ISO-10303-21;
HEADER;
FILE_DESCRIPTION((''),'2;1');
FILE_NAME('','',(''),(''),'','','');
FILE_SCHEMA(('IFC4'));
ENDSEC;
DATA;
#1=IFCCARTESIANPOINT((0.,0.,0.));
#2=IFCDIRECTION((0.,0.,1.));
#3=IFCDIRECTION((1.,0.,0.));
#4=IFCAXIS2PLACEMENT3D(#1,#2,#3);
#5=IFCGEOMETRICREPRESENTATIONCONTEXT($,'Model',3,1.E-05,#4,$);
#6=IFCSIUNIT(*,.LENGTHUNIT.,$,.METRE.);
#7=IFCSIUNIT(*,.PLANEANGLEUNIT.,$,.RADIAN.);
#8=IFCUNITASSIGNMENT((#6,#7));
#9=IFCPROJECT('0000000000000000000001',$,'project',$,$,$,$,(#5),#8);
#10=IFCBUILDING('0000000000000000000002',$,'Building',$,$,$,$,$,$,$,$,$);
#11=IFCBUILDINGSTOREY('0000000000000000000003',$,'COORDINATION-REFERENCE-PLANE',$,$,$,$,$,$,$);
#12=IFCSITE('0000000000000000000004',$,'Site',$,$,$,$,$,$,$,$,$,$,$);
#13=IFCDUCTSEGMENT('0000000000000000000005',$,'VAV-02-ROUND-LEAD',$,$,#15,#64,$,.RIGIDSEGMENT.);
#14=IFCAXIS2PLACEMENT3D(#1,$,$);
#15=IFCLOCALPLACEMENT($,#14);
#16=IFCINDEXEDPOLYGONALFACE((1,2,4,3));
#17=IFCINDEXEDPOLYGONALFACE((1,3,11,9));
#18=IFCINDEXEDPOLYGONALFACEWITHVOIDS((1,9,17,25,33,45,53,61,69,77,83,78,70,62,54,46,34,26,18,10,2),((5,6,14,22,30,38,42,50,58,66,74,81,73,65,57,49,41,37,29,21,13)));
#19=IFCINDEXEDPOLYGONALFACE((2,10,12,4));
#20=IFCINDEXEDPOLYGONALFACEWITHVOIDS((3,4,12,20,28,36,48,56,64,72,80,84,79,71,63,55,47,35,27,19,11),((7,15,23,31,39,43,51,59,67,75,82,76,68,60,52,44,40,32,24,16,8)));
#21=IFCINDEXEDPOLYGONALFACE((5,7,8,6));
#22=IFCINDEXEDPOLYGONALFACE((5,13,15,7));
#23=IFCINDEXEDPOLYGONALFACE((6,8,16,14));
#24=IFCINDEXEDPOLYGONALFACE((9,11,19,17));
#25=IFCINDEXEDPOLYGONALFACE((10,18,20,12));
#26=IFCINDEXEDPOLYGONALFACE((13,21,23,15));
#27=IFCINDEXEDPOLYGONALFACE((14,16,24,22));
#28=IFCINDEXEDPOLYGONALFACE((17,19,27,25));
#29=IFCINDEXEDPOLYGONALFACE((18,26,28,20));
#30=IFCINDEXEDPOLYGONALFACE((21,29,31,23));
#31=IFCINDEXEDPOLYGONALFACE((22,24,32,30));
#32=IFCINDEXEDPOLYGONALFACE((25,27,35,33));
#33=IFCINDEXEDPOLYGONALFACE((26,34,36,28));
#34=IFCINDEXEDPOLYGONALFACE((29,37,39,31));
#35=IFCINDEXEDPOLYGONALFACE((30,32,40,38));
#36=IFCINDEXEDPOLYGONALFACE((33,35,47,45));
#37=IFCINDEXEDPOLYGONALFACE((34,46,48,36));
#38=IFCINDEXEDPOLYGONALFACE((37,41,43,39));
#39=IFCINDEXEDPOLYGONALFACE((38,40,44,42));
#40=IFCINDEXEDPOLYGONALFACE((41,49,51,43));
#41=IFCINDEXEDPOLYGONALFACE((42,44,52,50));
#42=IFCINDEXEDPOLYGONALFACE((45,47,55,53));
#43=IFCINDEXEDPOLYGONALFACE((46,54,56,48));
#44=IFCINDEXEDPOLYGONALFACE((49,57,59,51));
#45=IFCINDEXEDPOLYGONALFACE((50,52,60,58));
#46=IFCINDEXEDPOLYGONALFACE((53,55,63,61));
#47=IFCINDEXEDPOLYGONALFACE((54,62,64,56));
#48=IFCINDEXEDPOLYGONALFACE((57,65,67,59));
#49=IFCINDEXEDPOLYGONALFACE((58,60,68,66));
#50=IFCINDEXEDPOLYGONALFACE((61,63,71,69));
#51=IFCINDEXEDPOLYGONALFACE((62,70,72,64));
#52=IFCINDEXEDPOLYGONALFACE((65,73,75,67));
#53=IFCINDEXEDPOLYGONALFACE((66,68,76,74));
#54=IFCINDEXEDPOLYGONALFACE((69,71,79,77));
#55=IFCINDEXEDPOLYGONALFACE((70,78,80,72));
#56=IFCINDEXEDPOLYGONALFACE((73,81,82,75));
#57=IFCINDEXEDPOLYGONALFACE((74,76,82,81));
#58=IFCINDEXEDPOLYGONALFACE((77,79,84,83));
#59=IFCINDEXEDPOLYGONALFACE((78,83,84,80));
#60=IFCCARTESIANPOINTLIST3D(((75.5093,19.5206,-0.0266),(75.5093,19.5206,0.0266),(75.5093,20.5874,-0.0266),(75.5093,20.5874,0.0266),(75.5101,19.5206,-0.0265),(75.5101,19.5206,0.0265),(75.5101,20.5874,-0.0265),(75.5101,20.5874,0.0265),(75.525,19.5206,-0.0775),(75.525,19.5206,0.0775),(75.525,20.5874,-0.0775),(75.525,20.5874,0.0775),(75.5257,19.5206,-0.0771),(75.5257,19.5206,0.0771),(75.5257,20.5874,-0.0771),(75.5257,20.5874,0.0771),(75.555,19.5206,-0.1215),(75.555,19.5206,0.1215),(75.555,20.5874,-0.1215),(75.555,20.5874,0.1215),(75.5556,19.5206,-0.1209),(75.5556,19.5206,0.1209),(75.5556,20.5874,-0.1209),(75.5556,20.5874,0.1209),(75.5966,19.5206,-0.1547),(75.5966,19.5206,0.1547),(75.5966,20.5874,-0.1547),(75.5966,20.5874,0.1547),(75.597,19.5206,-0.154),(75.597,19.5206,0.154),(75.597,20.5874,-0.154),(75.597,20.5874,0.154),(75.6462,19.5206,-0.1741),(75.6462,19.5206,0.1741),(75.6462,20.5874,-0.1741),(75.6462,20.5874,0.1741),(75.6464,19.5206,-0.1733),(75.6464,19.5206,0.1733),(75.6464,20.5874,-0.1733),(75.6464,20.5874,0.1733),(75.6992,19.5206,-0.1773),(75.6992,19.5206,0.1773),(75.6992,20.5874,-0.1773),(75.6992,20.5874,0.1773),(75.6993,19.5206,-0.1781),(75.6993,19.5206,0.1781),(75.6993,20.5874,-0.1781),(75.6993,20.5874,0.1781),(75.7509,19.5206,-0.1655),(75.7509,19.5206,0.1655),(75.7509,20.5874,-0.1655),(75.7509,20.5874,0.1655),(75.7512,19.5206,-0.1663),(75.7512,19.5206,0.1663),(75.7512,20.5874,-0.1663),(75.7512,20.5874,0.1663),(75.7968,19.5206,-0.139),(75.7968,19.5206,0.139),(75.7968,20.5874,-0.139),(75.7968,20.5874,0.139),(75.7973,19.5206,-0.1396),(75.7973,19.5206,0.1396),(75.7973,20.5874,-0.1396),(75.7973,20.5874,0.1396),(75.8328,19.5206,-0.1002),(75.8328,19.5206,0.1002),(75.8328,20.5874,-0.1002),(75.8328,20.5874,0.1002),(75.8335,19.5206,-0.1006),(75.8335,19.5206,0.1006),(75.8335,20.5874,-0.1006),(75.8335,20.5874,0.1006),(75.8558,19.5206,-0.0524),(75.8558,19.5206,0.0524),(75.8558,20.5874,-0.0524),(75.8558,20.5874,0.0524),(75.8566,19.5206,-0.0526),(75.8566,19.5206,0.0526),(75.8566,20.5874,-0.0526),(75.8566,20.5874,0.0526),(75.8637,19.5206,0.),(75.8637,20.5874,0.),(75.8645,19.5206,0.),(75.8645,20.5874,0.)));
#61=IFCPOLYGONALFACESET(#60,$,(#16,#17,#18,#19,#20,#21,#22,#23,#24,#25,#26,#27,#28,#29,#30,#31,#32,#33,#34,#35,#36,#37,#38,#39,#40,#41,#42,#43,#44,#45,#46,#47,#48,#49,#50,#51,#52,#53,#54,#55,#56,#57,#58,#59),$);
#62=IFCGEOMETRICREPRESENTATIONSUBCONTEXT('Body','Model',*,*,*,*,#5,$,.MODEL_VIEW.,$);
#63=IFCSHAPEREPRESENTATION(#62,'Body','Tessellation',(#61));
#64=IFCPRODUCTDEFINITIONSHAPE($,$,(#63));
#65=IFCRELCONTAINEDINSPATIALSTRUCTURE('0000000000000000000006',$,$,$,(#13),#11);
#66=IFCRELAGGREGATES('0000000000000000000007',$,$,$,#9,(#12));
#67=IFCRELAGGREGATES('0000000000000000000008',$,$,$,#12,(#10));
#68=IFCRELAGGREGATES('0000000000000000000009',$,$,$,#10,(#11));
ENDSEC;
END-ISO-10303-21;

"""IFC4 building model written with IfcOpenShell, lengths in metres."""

from ifc_helpers import new_model, si_unit, frame, origin, origin_with_axes, place, context, subcontext, project, spatial, hollow_circle, extrude, element, save


model = new_model("IFC4")

# Units and contexts
model_context_1 = context("Model", 3, precision=1e-05, world=origin_with_axes())
body_context_1 = subcontext(model_context_1, "Body", "Model", "MODEL_VIEW")
ifc_project = project(units=[si_unit("LENGTHUNIT", "METRE"), si_unit("PLANEANGLEUNIT", "RADIAN")], contexts=[model_context_1])

# Site, building, storey
site = spatial("IfcSite", under=ifc_project, Name="Site")
building = spatial("IfcBuilding", under=site, Name="Building")
storey = spatial("IfcBuildingStorey", under=building, Name="COORDINATION-REFERENCE-PLANE")

# Duct segment
duct_segment_1_placement = place(None, frame((75.6859, 20.5874, 0.0), z_axis=(0.0, -1.0, 0.0), x_axis=(1.0, 0.0, 0.0)))
element("IfcDuctSegment", 1, at=duct_segment_1_placement, inside=storey, Name="VAV-02-ROUND-LEAD", PredefinedType="RIGIDSEGMENT", context=body_context_1, shape_type="SweptSolid", body=[
    extrude(hollow_circle(Radius=0.1786, WallThickness=0.0008), origin(), (0.0, 0.0, 1.0), 1.0668),
])

save(model, "model.ifc")
